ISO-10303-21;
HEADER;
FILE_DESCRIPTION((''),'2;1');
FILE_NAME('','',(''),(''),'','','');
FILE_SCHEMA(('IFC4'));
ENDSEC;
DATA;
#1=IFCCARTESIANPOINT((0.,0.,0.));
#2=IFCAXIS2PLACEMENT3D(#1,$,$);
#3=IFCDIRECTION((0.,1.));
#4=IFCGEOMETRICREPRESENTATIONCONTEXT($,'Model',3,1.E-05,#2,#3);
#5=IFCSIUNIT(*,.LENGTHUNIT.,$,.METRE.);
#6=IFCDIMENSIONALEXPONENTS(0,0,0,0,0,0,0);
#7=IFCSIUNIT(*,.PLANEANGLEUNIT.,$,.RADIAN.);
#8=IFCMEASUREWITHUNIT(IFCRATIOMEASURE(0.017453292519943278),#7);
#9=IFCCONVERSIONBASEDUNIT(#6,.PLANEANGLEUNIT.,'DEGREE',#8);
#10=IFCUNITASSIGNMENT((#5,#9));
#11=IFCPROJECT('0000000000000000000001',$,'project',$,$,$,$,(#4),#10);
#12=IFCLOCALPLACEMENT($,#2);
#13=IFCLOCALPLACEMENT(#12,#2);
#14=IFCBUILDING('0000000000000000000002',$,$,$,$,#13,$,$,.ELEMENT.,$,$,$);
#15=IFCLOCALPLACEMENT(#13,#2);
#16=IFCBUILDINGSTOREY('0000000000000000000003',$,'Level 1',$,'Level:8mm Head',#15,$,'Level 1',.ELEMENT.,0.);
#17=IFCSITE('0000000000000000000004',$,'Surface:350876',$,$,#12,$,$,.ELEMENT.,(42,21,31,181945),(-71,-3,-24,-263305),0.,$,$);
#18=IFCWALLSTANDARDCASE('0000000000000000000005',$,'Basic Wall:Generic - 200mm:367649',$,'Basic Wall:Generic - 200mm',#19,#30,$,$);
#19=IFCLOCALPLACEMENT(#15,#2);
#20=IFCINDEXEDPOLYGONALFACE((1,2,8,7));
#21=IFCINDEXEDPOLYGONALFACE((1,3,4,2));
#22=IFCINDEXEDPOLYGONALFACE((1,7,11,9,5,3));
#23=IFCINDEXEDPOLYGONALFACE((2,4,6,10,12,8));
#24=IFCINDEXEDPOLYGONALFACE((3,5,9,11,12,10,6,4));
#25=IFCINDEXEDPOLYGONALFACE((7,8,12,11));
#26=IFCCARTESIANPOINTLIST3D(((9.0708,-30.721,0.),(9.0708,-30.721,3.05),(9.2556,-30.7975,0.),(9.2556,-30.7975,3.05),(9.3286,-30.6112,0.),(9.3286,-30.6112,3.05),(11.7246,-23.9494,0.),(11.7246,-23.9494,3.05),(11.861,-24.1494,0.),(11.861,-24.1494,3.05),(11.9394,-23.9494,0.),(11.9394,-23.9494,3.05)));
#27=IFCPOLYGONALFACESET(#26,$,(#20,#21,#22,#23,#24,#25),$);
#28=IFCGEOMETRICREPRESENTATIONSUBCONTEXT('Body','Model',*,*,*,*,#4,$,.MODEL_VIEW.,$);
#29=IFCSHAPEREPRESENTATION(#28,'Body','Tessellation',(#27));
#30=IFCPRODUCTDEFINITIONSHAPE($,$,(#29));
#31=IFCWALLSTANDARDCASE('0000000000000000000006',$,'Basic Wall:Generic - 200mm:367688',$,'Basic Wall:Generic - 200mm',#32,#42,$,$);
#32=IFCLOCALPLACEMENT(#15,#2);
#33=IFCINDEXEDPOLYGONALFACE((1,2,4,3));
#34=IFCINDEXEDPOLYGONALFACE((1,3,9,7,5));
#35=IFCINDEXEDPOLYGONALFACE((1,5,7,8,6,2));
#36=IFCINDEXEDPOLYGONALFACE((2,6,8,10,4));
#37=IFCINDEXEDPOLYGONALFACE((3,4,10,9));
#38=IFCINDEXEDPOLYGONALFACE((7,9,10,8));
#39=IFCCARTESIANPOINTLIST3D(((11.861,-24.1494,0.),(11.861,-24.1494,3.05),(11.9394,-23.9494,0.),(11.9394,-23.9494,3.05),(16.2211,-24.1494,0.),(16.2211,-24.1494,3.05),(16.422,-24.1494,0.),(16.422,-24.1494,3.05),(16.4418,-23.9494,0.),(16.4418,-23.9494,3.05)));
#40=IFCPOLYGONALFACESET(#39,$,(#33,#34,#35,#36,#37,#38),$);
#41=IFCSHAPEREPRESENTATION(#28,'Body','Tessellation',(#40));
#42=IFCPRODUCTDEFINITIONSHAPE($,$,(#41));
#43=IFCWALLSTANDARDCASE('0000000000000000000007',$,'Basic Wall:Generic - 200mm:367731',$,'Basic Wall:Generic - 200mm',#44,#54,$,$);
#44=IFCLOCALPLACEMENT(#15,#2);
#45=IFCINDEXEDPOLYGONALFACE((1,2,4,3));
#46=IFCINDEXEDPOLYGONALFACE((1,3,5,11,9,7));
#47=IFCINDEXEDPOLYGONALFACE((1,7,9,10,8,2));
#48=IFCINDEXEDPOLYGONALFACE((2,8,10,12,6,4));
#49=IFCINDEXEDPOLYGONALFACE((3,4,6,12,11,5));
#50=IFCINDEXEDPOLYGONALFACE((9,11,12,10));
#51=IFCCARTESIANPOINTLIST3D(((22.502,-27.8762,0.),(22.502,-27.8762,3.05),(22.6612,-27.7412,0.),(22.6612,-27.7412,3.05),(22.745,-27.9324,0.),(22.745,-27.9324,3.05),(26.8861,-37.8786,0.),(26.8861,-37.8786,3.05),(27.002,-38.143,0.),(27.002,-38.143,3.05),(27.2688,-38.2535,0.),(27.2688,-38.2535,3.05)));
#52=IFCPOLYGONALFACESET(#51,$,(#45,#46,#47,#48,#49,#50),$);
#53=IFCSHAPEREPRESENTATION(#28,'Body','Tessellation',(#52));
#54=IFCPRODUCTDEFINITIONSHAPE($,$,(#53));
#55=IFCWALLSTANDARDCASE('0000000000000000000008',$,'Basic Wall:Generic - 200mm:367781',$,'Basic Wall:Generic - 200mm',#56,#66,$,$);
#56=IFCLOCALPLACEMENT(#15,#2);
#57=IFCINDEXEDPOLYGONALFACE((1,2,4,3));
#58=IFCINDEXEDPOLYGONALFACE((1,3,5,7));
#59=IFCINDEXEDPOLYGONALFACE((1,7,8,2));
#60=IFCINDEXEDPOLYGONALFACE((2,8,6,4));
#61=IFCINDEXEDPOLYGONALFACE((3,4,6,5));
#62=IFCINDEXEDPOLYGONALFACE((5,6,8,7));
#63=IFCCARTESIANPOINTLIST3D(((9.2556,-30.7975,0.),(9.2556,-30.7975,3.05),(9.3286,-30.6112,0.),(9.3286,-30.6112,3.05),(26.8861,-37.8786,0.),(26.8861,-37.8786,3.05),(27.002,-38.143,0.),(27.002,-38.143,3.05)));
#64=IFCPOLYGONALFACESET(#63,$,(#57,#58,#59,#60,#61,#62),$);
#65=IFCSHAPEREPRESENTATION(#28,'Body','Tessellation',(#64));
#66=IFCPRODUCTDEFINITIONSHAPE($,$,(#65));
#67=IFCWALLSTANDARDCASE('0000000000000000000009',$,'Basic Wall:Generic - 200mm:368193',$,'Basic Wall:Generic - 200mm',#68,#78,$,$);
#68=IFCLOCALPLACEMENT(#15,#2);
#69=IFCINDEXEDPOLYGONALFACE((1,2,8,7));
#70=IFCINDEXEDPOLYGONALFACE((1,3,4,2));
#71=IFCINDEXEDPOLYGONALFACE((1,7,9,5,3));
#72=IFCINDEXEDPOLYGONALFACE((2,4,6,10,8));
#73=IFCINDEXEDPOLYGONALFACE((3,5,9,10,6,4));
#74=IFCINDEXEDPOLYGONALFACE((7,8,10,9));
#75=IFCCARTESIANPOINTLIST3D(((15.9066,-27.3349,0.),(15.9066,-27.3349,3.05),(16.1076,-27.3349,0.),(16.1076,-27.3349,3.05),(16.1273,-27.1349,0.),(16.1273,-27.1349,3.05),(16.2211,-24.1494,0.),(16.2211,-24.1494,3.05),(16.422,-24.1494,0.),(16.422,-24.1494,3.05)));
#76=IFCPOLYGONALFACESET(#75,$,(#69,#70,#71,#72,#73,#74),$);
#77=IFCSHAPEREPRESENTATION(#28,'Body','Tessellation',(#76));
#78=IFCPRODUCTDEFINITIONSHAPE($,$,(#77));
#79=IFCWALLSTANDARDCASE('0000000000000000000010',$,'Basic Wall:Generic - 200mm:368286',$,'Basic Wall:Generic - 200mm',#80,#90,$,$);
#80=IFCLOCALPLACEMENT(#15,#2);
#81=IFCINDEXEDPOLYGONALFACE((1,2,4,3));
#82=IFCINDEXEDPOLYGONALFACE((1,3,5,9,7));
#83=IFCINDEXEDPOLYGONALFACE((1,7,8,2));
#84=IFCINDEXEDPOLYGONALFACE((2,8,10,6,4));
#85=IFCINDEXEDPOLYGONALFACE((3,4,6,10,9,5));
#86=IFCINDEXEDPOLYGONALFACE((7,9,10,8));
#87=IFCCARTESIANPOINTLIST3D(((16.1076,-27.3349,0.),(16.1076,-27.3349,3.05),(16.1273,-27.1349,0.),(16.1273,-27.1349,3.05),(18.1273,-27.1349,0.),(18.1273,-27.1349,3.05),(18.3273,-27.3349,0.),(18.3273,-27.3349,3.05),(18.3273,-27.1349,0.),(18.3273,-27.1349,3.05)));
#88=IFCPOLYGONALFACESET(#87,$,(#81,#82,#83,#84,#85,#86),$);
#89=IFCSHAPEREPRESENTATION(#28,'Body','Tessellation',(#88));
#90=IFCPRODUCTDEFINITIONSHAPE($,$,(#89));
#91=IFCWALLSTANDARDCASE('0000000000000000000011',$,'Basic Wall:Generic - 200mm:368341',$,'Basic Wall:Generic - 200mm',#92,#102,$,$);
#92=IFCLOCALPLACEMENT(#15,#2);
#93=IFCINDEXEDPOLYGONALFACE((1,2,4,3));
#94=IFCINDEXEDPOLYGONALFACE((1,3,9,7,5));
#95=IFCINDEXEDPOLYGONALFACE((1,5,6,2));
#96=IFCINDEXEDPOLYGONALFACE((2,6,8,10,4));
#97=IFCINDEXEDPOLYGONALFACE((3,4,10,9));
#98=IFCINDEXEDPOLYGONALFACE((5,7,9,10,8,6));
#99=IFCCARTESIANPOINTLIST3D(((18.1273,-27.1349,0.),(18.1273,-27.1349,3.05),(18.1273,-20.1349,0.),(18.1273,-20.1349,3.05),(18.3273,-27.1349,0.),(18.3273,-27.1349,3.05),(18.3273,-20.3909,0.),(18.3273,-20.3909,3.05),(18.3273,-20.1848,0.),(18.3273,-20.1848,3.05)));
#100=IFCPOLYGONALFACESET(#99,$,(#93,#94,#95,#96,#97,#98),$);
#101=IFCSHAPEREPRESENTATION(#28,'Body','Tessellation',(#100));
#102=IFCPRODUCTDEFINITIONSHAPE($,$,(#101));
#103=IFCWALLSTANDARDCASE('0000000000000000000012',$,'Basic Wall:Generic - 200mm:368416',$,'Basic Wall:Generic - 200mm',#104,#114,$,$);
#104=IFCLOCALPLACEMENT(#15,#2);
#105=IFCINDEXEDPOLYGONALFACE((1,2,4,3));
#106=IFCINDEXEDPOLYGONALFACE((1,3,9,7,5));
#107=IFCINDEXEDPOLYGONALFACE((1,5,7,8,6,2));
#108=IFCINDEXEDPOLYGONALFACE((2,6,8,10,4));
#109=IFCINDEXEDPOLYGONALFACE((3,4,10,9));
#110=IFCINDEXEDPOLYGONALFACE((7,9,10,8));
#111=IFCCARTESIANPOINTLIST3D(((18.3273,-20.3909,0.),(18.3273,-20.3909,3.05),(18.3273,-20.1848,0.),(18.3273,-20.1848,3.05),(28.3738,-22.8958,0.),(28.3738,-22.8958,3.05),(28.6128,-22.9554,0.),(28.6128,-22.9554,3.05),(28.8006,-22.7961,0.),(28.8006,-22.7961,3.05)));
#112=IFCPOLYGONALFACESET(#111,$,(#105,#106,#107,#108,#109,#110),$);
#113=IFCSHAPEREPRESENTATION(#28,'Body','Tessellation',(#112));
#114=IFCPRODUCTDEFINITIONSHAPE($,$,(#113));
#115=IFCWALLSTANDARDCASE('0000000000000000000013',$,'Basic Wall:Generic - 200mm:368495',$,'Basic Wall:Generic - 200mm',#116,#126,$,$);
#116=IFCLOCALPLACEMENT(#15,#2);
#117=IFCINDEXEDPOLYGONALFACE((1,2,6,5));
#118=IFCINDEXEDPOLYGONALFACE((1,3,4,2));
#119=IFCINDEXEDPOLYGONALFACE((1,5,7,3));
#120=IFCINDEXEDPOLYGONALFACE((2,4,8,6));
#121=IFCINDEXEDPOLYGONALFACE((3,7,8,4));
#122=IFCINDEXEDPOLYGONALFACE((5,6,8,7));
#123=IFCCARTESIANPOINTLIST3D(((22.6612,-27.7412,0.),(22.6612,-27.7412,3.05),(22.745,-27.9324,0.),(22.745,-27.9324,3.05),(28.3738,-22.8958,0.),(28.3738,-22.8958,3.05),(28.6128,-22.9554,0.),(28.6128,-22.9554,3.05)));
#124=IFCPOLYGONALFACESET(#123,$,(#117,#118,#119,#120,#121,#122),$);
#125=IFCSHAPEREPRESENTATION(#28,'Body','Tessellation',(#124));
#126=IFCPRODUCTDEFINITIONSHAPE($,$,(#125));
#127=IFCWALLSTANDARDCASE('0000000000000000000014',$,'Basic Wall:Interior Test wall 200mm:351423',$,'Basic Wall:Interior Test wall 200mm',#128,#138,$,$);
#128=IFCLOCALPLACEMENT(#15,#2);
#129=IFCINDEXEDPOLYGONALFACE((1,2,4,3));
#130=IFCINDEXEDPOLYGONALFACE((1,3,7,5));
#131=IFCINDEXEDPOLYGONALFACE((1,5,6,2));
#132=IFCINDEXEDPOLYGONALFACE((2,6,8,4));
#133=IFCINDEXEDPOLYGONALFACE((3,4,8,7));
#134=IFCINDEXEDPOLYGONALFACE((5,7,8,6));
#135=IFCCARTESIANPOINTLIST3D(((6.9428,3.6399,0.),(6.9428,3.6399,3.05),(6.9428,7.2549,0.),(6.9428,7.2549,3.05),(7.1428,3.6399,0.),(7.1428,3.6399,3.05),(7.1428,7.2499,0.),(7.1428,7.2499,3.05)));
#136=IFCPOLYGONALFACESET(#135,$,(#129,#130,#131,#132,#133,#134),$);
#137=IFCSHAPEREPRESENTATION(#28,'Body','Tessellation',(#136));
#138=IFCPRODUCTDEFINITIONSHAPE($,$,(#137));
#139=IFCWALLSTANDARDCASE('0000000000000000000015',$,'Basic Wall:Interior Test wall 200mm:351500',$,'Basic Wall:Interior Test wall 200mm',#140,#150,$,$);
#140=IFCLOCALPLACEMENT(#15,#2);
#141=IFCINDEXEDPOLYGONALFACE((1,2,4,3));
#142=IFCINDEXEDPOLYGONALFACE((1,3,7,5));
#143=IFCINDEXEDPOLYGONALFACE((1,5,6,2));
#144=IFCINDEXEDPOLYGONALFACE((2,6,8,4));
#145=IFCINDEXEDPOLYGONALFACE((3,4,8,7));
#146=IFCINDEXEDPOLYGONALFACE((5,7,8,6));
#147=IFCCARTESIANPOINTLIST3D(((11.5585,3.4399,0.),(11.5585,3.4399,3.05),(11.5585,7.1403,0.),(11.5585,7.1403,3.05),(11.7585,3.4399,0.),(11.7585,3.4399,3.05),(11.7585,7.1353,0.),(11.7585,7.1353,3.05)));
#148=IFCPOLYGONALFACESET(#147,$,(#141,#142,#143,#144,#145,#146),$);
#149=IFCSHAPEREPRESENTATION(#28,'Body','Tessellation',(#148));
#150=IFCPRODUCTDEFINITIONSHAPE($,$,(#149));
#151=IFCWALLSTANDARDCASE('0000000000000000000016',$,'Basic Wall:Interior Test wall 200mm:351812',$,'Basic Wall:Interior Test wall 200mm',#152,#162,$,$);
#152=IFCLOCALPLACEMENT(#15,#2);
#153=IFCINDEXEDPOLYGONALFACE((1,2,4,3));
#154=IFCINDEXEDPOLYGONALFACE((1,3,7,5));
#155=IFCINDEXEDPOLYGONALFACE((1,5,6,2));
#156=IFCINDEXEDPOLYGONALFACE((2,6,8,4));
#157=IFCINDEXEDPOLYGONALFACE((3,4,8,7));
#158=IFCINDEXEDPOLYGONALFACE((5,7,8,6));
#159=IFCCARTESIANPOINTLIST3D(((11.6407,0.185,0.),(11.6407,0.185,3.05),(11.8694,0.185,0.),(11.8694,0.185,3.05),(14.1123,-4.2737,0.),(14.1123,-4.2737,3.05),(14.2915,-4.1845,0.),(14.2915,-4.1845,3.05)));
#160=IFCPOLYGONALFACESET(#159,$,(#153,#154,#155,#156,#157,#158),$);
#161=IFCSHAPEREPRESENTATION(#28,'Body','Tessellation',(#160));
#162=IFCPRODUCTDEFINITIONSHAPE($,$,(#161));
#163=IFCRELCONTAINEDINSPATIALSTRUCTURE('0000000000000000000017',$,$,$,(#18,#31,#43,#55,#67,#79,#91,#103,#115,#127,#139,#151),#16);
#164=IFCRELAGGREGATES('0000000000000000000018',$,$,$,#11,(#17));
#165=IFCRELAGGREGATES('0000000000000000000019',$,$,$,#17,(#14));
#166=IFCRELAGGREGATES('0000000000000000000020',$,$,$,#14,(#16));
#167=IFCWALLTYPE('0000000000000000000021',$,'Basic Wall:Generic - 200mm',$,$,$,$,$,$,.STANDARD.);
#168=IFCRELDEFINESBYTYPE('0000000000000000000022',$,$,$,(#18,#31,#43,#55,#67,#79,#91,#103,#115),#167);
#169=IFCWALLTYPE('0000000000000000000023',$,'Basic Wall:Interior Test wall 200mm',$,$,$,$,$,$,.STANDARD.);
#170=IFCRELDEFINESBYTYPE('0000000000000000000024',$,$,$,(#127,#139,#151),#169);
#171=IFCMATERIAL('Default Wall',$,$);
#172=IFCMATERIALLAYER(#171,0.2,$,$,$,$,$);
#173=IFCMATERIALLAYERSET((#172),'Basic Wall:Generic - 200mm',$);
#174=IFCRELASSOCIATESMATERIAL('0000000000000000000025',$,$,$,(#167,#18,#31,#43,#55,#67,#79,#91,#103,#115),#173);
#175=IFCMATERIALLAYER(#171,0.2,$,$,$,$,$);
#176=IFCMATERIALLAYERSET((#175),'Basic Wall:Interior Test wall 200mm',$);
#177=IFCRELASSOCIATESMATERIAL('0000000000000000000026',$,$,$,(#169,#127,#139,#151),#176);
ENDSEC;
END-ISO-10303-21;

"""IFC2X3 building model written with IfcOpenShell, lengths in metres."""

from ifc_helpers import new_model, entity, si_unit, converted_unit, direction, frame, origin, place, context, subcontext, project, spatial, polyline, outline, extrude, clip, bounded_halfspace, material, layer, layer_set, layer_usage, type_object, element, save


model = new_model("IFC2X3")

# Units and contexts
model_context = context("Model", 3, precision=1e-05, world=origin(), true_north=direction((0.0, 1.0)))
body_context = subcontext(model_context, "Body", "Model", "MODEL_VIEW")
ifc_project = project(units=[si_unit("LENGTHUNIT", "METRE"), converted_unit("PLANEANGLEUNIT", "DEGREE", entity("IfcRatioMeasure", 0.017453292519943278), si_unit("PLANEANGLEUNIT", "RADIAN"), dimensions=[0, 0, 0, 0, 0, 0, 0])], contexts=[model_context])

# Site, building, storey
site_placement = place(None, origin())
site = spatial("IfcSite", under=ifc_project, at=site_placement, Name="Surface:350876", CompositionType="ELEMENT", RefLatitude=(42, 21, 31, 181945), RefLongitude=(-71, -3, -24, -263305), RefElevation=0.0)
building_placement = place(site_placement, origin())
building = spatial("IfcBuilding", under=site, at=building_placement, CompositionType="ELEMENT")
storey_placement = place(building_placement, origin())
storey = spatial("IfcBuildingStorey", under=building, at=storey_placement, Name="Level 1", ObjectType="Level:8mm Head", LongName="Level 1", CompositionType="ELEMENT", Elevation=0.0)

# Shared definitions
ifc_material_1 = material(Name="Default Wall")
ifc_layer_1 = layer(ifc_material_1, 0.2)
ifc_layer_set_1 = layer_set([ifc_layer_1], Name="Basic Wall:Generic - 200mm")
wall_type_1 = type_object("IfcWallType", Name="Basic Wall:Generic - 200mm", PredefinedType="STANDARD", material=ifc_layer_set_1)

# Walls
ifc_layer_usage_1 = layer_usage(ifc_layer_set_1, "AXIS2", "NEGATIVE", 0.1)
wall_1_placement = place(storey_placement, frame((9.1625, -30.761, 0.0), z_axis=(0.0, 0.0, 1.0), x_axis=(0.364882, 0.931054, 0.0)))
element("IfcWallStandardCase", 1, at=wall_1_placement, inside=storey, type_object=wall_type_1, material=ifc_layer_usage_1, Name="Basic Wall:Generic - 200mm:367649", ObjectType="Basic Wall:Generic - 200mm", context=body_context, shape_type="SweptSolid", body=[
    extrude(outline(polyline([(7.3551, -0.1), (7.2767, 0.1), (0.0038, 0.1), (0.0, -0.1), (0.2, -0.1), (7.1403, -0.1), (7.3551, -0.1)])), origin(), (0.0, 0.0, 1.0), 3.05),
])
ifc_layer_usage_2 = layer_usage(ifc_layer_set_1, "AXIS2", "NEGATIVE", 0.1)
wall_2_placement = place(storey_placement, frame((11.861, -24.0494, 0.0)))
element("IfcWallStandardCase", 2, at=wall_2_placement, inside=storey, type_object=wall_type_1, material=ifc_layer_usage_2, Name="Basic Wall:Generic - 200mm:367688", ObjectType="Basic Wall:Generic - 200mm", context=body_context, shape_type="SweptSolid", body=[
    extrude(outline(polyline([(4.561, -0.1), (4.5808, 0.1), (0.0784, 0.1), (0.0, -0.1), (4.3601, -0.1), (4.561, -0.1)])), origin(), (0.0, 0.0, 1.0), 3.05),
])
ifc_layer_usage_3 = layer_usage(ifc_layer_set_1, "AXIS2", "NEGATIVE", 0.1)
wall_3_placement = place(storey_placement, frame((22.5696, -27.7813, 0.0), z_axis=(0.0, 0.0, 1.0), x_axis=(0.401436, -0.915887, 0.0)))
element("IfcWallStandardCase", 3, at=wall_3_placement, inside=storey, type_object=wall_type_1, material=ifc_layer_usage_3, Name="Basic Wall:Generic - 200mm:367731", ObjectType="Basic Wall:Generic - 200mm", context=body_context, shape_type="SweptSolid", body=[
    extrude(outline(polyline([(11.2695, -0.1), (11.4777, 0.1), (0.2087, 0.1), (0.0, 0.1), (0.0598, -0.1), (10.9808, -0.1), (11.2695, -0.1)])), origin(), (0.0, 0.0, 1.0), 3.05),
])
ifc_layer_usage_4 = layer_usage(ifc_layer_set_1, "AXIS2", "NEGATIVE", 0.1)
wall_4_placement = place(storey_placement, frame((27.0403, -38.0506, 0.0), z_axis=(0.0, 0.0, 1.0), x_axis=(-0.923975, 0.382452, 0.0)))
element("IfcWallStandardCase", 4, at=wall_4_placement, inside=storey, type_object=wall_type_1, material=ifc_layer_usage_4, Name="Basic Wall:Generic - 200mm:367781", ObjectType="Basic Wall:Generic - 200mm", context=body_context, shape_type="SweptSolid", body=[
    extrude(outline(polyline([(19.2103, -0.1), (19.2065, 0.1), (0.0, 0.1), (0.2082, -0.1), (19.2103, -0.1)])), origin(), (0.0, 0.0, 1.0), 3.05),
])
ifc_layer_usage_5 = layer_usage(ifc_layer_set_1, "AXIS2", "NEGATIVE", 0.1)
wall_5_placement = place(storey_placement, frame((16.3225, -24.1396, 0.0), z_axis=(0.0, 0.0, 1.0), x_axis=(-0.098237, -0.995163, 0.0)))
element("IfcWallStandardCase", 5, at=wall_5_placement, inside=storey, type_object=wall_type_1, material=ifc_layer_usage_5, Name="Basic Wall:Generic - 200mm:368193", ObjectType="Basic Wall:Generic - 200mm", context=body_context, shape_type="SweptSolid", body=[
    extrude(outline(polyline([(3.2207, -0.1), (3.201, 0.1), (3.0, 0.1), (0.0, 0.1), (0.0197, -0.1), (3.2207, -0.1)])), origin(), (0.0, 0.0, 1.0), 3.05),
])
ifc_layer_usage_6 = layer_usage(ifc_layer_set_1, "AXIS2", "NEGATIVE", 0.1)
wall_6_placement = place(storey_placement, frame((16.1076, -27.2349, 0.0)))
element("IfcWallStandardCase", 6, at=wall_6_placement, inside=storey, type_object=wall_type_1, material=ifc_layer_usage_6, Name="Basic Wall:Generic - 200mm:368286", ObjectType="Basic Wall:Generic - 200mm", context=body_context, shape_type="SweptSolid", body=[
    extrude(outline(polyline([(2.2197, -0.1), (2.2197, 0.1), (2.0197, 0.1), (0.0197, 0.1), (0.0, -0.1), (2.2197, -0.1)])), origin(), (0.0, 0.0, 1.0), 3.05),
])
ifc_layer_usage_7 = layer_usage(ifc_layer_set_1, "AXIS2", "NEGATIVE", 0.1)
wall_7_placement = place(storey_placement, frame((18.2273, -27.1349, 0.0), z_axis=(0.0, 0.0, 1.0), x_axis=(0.0, 1.0, 0.0)))
element("IfcWallStandardCase", 7, at=wall_7_placement, inside=storey, type_object=wall_type_1, material=ifc_layer_usage_7, Name="Basic Wall:Generic - 200mm:368341", ObjectType="Basic Wall:Generic - 200mm", context=body_context, shape_type="SweptSolid", body=[
    extrude(outline(polyline([(6.9501, -0.1), (7.0, 0.1), (0.0, 0.1), (0.0, -0.1), (6.744, -0.1), (6.9501, -0.1)])), origin(), (0.0, 0.0, 1.0), 3.05),
])
ifc_layer_usage_8 = layer_usage(ifc_layer_set_1, "AXIS2", "NEGATIVE", 0.1)
wall_8_placement = place(storey_placement, frame((18.3031, -20.2818, 0.0), z_axis=(0.0, 0.0, 1.0), x_axis=(0.970296, -0.241922, 0.0)))
element("IfcWallStandardCase", 8, at=wall_8_placement, inside=storey, type_object=wall_type_1, material=ifc_layer_usage_8, Name="Basic Wall:Generic - 200mm:368416", ObjectType="Basic Wall:Generic - 200mm", context=body_context, shape_type="SweptSolid", body=[
    extrude(outline(polyline([(10.6502, -0.1), (10.7939, 0.1), (0.0, 0.1), (0.0499, -0.1), (10.4039, -0.1), (10.6502, -0.1)])), origin(), (0.0, 0.0, 1.0), 3.05),
])
ifc_layer_usage_9 = layer_usage(ifc_layer_set_1, "AXIS2", "NEGATIVE", 0.1)
wall_9_placement = place(storey_placement, frame((28.5481, -22.8791, 0.0), z_axis=(0.0, 0.0, 1.0), x_axis=(-0.762621, -0.646846, 0.0)))
element("IfcWallStandardCase", 9, at=wall_9_placement, inside=storey, type_object=wall_type_1, material=ifc_layer_usage_9, Name="Basic Wall:Generic - 200mm:368495", ObjectType="Basic Wall:Generic - 200mm", context=body_context, shape_type="SweptSolid", body=[
    extrude(outline(polyline([(7.6345, -0.1), (7.6942, 0.1), (0.0, 0.1), (0.1437, -0.1), (7.6345, -0.1)])), origin(), (0.0, 0.0, 1.0), 3.05),
])
ifc_layer_2 = layer(ifc_material_1, 0.2)
ifc_layer_set_2 = layer_set([ifc_layer_2], Name="Basic Wall:Interior Test wall 200mm")
ifc_layer_usage_10 = layer_usage(ifc_layer_set_2, "AXIS2", "NEGATIVE", 0.1)
wall_type_2 = type_object("IfcWallType", Name="Basic Wall:Interior Test wall 200mm", PredefinedType="STANDARD", material=ifc_layer_set_2)
wall_10_placement = place(storey_placement, frame((7.0428, 3.6399, 0.0), z_axis=(0.0, 0.0, 1.0), x_axis=(0.0, 1.0, 0.0)))
element("IfcWallStandardCase", 10, at=wall_10_placement, inside=storey, type_object=wall_type_2, material=ifc_layer_usage_10, Name="Basic Wall:Interior Test wall 200mm:351423", ObjectType="Basic Wall:Interior Test wall 200mm", context=body_context, shape_type="Clipping", body=[
    clip(extrude(outline(polyline([(3.61, -0.1), (3.6149, 0.1), (0.0, 0.1), (0.0, -0.1), (3.61, -0.1)])), origin(), (0.0, 0.0, 1.0), 3.05), bounded_halfspace(frame((0.0, -0.1, 3.05), z_axis=(0.0, 0.0, -1.0), x_axis=(0.97437, -0.224951, 0.0)), True, frame((0.0, -0.1, 3.05)), polyline([(0.0, 0.0), (3.61, 0.0), (3.6149, 0.2), (0.0, 0.2), (0.0, 0.0)]))),
])
ifc_layer_usage_11 = layer_usage(ifc_layer_set_2, "AXIS2", "NEGATIVE", 0.1)
wall_11_placement = place(storey_placement, frame((11.6585, 7.1403, 0.0), z_axis=(0.0, 0.0, 1.0), x_axis=(0.0, -1.0, 0.0)))
element("IfcWallStandardCase", 11, at=wall_11_placement, inside=storey, type_object=wall_type_2, material=ifc_layer_usage_11, Name="Basic Wall:Interior Test wall 200mm:351500", ObjectType="Basic Wall:Interior Test wall 200mm", context=body_context, shape_type="Clipping", body=[
    clip(extrude(outline(polyline([(3.7004, -0.1), (3.7004, 0.1), (0.005, 0.1), (0.0, -0.1), (3.5004, -0.1), (3.7004, -0.1)])), origin(), (0.0, 0.0, 1.0), 3.05), bounded_halfspace(frame((0.0, -0.1, 3.05), z_axis=(0.0, 0.0, -1.0), x_axis=(-0.97437, 0.224951, 0.0)), True, frame((0.0, -0.1, 3.05)), polyline([(0.0, 0.0), (3.5004, 0.0), (3.7004, 0.0), (3.7004, 0.2), (0.005, 0.2), (0.0, 0.0)]))),
])
ifc_layer_usage_12 = layer_usage(ifc_layer_set_2, "AXIS2", "NEGATIVE", 0.1)
wall_12_placement = place(storey_placement, frame((11.7282, 0.2335, 0.0), z_axis=(0.0, 0.0, 1.0), x_axis=(0.48481, -0.87462, 0.0)))
element("IfcWallStandardCase", 12, at=wall_12_placement, inside=storey, type_object=wall_type_2, material=ifc_layer_usage_12, Name="Basic Wall:Interior Test wall 200mm:351812", ObjectType="Basic Wall:Interior Test wall 200mm", context=body_context, shape_type="Clipping", body=[
    clip(extrude(outline(polyline([(5.0979, -0.1), (5.1068, 0.1), (0.1109, 0.1), (0.0, -0.1), (5.0979, -0.1)])), origin(), (0.0, 0.0, 1.0), 3.05), bounded_halfspace(frame((0.0, -0.1, 3.05), z_axis=(0.0, 0.0, -1.0), x_axis=(-0.743145, 0.669131, 0.0)), True, frame((0.0, -0.1, 3.05)), polyline([(0.0, 0.0), (5.0979, 0.0), (5.1068, 0.2), (0.1109, 0.2), (0.0, 0.0)]))),
])

save(model, "model.ifc")
